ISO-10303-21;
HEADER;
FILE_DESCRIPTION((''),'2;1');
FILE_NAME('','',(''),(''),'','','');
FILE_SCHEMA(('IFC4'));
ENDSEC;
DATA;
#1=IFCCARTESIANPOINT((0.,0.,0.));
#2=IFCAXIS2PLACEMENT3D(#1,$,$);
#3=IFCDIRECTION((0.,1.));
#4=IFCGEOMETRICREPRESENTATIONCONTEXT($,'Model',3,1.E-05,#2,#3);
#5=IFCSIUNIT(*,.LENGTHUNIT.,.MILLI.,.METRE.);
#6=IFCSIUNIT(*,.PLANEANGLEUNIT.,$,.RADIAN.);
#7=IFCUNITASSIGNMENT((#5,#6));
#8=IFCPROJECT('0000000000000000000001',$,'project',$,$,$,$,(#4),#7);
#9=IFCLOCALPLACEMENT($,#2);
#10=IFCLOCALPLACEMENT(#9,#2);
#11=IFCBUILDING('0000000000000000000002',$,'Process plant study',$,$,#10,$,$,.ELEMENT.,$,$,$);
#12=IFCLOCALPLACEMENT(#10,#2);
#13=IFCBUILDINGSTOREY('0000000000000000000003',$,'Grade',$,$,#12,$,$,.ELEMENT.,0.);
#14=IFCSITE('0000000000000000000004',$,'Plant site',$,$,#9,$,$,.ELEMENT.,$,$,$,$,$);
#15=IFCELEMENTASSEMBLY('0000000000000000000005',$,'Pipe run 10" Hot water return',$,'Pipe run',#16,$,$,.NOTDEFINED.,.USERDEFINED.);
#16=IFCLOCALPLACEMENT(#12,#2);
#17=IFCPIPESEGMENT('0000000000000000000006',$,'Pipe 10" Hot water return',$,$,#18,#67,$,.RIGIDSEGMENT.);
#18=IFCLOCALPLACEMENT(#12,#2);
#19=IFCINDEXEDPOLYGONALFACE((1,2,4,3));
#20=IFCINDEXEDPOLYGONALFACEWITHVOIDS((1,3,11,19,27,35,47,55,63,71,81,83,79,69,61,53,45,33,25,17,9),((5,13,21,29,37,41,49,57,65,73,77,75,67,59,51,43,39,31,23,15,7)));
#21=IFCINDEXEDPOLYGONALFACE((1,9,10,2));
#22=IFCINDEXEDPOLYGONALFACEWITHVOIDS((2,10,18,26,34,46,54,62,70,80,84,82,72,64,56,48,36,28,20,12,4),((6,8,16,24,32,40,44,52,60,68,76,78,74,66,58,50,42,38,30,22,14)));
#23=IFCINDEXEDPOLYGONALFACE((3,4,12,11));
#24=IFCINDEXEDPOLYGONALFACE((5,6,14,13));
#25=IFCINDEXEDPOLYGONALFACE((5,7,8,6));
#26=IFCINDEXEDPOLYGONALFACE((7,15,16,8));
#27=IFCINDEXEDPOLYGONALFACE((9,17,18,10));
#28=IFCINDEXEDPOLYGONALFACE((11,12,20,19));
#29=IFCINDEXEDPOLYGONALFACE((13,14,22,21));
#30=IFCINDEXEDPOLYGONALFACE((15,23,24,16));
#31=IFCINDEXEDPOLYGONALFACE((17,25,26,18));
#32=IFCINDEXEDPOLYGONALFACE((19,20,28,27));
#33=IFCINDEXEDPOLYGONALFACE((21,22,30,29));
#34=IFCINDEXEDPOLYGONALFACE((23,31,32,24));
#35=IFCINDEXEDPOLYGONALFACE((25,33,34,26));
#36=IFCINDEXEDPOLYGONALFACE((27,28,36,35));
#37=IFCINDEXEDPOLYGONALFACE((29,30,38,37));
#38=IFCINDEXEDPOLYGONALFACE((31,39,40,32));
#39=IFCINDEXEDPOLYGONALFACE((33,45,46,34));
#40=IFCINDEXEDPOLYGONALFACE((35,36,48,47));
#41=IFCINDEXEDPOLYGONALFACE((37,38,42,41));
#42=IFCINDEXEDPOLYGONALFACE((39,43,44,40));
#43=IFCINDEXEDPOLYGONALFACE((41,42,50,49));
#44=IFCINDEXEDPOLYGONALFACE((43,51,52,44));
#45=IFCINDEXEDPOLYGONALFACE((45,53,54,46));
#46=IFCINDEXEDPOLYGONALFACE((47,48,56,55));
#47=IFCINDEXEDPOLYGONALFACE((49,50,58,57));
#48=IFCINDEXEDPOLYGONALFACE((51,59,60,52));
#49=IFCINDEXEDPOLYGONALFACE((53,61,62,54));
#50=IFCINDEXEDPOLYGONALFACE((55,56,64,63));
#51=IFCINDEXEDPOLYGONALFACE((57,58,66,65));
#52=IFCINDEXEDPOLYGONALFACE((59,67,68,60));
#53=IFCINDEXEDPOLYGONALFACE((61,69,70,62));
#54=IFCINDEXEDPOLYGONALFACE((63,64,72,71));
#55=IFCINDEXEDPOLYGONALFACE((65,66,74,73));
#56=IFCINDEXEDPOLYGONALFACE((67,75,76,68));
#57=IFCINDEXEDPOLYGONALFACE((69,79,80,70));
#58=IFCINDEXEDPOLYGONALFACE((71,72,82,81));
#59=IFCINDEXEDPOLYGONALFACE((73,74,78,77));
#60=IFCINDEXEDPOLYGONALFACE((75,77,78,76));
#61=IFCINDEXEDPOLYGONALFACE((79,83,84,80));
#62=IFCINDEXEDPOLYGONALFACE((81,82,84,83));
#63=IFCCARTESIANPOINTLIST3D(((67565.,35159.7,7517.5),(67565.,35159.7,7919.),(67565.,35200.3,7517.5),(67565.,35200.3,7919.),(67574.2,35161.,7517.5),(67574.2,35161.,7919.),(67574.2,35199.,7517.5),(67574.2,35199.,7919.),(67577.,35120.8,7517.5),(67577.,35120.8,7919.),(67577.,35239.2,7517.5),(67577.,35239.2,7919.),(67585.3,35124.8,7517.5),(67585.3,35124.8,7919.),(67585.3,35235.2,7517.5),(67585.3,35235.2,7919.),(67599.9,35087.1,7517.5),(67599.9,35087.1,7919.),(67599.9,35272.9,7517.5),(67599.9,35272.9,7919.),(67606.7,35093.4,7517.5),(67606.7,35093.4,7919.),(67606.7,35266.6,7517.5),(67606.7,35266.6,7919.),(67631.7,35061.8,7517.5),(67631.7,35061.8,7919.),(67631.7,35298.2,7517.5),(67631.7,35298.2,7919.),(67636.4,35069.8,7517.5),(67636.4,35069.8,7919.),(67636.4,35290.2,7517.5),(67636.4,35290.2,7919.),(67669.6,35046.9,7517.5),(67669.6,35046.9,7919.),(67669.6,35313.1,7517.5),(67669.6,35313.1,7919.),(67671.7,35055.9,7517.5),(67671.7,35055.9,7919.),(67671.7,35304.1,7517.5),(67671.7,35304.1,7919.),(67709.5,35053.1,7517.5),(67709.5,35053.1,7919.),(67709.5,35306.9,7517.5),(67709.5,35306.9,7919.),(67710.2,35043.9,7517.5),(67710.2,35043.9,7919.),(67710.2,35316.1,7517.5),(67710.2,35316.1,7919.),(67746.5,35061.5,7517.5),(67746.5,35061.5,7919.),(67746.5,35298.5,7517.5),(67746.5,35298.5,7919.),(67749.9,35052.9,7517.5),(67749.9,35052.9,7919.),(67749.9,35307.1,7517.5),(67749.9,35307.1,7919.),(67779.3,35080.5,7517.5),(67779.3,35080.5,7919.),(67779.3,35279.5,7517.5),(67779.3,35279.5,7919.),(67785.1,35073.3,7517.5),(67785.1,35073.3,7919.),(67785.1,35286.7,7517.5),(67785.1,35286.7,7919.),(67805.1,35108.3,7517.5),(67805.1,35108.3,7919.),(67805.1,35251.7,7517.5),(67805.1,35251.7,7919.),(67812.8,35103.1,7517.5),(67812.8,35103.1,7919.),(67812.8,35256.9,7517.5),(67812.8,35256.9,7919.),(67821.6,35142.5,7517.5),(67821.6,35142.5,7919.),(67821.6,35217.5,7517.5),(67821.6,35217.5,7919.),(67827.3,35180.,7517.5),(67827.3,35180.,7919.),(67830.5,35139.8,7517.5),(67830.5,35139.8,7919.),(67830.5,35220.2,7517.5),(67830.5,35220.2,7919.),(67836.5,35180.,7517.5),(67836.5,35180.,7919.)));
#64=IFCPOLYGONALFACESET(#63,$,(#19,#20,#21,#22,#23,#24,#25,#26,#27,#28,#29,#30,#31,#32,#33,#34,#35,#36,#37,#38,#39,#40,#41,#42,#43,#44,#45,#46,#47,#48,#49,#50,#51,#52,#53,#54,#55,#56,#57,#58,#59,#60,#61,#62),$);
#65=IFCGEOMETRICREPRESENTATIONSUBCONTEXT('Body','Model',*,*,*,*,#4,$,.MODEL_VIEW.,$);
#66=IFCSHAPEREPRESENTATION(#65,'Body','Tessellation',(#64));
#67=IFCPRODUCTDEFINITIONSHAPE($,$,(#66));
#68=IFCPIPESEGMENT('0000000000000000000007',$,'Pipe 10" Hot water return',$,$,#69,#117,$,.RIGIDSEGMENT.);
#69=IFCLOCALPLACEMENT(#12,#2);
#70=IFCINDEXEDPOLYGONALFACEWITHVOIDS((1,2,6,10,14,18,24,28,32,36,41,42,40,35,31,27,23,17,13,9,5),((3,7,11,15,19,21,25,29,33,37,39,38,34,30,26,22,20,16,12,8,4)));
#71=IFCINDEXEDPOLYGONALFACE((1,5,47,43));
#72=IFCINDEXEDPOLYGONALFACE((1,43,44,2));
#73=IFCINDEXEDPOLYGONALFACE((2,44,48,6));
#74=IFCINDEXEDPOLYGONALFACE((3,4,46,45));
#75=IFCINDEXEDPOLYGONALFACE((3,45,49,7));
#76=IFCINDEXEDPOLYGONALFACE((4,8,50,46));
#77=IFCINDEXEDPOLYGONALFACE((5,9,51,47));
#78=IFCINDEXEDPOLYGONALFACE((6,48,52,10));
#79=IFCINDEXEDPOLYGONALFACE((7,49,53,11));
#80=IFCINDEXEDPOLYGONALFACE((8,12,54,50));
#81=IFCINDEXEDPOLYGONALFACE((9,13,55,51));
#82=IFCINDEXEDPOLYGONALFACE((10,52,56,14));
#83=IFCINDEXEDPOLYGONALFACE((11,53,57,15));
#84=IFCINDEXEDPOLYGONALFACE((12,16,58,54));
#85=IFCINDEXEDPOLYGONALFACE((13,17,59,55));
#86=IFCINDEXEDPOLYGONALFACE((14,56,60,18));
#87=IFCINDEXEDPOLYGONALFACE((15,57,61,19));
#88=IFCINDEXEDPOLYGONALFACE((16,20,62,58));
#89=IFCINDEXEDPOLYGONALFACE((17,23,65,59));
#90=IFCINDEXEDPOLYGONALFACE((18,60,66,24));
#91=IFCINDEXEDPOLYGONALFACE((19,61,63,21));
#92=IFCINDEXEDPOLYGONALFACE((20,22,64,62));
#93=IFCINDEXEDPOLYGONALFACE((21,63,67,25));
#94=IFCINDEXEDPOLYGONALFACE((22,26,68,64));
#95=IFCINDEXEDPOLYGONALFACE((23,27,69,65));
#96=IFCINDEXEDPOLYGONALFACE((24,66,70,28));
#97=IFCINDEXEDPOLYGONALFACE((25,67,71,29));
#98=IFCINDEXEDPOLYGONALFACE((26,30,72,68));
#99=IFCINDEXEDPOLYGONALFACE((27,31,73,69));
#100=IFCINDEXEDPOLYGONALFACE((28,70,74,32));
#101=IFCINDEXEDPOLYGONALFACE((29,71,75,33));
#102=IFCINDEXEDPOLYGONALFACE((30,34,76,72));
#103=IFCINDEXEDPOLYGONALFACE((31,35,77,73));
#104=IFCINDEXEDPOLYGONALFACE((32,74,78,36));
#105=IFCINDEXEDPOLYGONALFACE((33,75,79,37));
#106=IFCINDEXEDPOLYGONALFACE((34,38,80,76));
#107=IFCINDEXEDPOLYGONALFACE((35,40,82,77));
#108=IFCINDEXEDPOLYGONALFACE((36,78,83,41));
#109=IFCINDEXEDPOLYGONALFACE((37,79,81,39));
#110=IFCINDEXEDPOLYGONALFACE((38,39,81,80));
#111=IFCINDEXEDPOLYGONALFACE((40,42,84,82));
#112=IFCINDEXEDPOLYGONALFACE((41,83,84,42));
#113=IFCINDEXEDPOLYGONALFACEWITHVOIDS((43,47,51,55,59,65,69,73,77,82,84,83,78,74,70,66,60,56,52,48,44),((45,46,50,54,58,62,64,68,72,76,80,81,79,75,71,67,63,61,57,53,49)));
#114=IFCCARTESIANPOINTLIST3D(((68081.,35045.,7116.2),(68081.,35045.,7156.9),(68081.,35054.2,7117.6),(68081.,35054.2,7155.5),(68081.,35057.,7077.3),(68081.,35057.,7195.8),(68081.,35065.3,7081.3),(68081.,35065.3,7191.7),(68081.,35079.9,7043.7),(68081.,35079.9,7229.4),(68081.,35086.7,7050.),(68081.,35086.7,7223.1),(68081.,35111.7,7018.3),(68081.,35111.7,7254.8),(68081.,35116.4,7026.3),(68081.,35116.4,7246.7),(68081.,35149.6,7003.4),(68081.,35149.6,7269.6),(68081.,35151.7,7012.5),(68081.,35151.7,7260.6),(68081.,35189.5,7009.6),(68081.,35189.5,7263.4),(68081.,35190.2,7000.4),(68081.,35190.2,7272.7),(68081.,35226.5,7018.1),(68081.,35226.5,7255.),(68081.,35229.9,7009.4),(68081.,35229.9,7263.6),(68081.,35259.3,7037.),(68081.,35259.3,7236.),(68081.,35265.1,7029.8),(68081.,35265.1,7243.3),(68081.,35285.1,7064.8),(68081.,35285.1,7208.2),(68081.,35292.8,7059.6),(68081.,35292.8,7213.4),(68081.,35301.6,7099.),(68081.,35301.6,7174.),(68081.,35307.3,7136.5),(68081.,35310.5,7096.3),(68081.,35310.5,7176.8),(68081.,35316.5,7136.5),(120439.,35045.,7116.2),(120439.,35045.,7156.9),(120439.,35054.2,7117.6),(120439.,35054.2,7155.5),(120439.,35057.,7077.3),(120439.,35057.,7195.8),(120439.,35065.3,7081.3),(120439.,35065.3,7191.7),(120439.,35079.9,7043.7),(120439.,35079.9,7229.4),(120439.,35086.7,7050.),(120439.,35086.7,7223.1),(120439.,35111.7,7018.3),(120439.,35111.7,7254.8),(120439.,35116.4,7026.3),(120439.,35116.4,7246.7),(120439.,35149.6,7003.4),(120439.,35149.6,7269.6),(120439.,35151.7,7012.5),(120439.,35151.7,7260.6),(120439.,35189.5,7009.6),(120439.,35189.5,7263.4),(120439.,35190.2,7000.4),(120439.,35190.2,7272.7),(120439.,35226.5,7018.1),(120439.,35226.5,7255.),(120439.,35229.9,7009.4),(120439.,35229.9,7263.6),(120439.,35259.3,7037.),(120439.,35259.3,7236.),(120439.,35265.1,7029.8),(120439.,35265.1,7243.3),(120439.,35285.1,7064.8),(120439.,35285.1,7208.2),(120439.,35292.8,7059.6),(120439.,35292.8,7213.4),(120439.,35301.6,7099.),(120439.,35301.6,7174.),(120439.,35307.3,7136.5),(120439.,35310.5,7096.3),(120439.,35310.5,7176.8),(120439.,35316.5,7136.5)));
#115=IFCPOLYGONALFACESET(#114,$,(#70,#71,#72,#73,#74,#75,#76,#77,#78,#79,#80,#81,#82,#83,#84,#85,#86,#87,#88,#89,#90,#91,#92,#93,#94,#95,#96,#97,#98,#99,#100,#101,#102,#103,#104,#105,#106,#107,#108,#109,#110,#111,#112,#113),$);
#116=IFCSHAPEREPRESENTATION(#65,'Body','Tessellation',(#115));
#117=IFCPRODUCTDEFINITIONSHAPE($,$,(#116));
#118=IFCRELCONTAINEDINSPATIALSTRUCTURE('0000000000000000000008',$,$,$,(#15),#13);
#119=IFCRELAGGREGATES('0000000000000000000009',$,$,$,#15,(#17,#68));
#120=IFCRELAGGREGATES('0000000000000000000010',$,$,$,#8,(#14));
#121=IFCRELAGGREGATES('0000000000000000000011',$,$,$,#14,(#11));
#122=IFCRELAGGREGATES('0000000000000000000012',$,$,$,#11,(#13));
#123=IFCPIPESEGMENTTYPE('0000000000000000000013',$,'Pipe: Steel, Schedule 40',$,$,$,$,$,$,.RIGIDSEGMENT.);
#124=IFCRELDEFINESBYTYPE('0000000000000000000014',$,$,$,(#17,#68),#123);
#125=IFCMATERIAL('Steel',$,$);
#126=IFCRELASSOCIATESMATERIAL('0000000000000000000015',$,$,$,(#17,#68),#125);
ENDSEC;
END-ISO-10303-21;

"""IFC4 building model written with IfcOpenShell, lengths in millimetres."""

from ifc_helpers import new_model, si_unit, direction, frame, origin, origin_with_axes, origin_2d, place, context, subcontext, project, spatial, hollow_circle, extrude, material, type_object, element, aggregate, save


model = new_model("IFC4")

# Units and contexts
model_context = context("Model", 3, precision=1e-05, world=origin(), true_north=direction((0.0, 1.0)))
body_context = subcontext(model_context, "Body", "Model", "MODEL_VIEW")
ifc_project = project(units=[si_unit("LENGTHUNIT", "METRE", prefix="MILLI"), si_unit("PLANEANGLEUNIT", "RADIAN")], contexts=[model_context])

# Site, building, storey
site_placement = place(None, origin())
site = spatial("IfcSite", under=ifc_project, at=site_placement, Name="Plant site", CompositionType="ELEMENT")
building_placement = place(site_placement, origin())
building = spatial("IfcBuilding", under=site, at=building_placement, Name="Process plant study", CompositionType="ELEMENT")
storey_placement = place(building_placement, origin())
storey = spatial("IfcBuildingStorey", under=building, at=storey_placement, Name="Grade", CompositionType="ELEMENT", Elevation=0.0)

# Shared definitions
ifc_material = material(Name="Steel")
pipe_segment_type = type_object("IfcPipeSegmentType", Name="Pipe: Steel, Schedule 40", PredefinedType="RIGIDSEGMENT")

# Element assembly, pipe segments
assembly_1_placement = place(storey_placement, origin_with_axes())
assembly_1 = element("IfcElementAssembly", 1, at=assembly_1_placement, inside=storey, Name="Pipe run 10\" Hot water return", ObjectType="Pipe run", AssemblyPlace="NOTDEFINED", PredefinedType="USERDEFINED")
pipe_segment_1_placement = place(storey_placement, origin_with_axes())
pipe_segment_1 = element("IfcPipeSegment", 2, at=pipe_segment_1_placement, type_object=pipe_segment_type, material=ifc_material, Name="Pipe 10\" Hot water return", PredefinedType="RIGIDSEGMENT", context=body_context, shape_type="SweptSolid", body=[
    extrude(hollow_circle(Radius=136.5, WallThickness=9.3, at=origin_2d()), frame((67700.0, 35180.0, 7919.0), z_axis=(0.0, 0.0, -1.0), x_axis=(1.0, 0.0, 0.0)), (0.0, 0.0, 1.0), 401.5),
])
pipe_segment_2_placement = place(storey_placement, origin_with_axes())
pipe_segment_2 = element("IfcPipeSegment", 3, at=pipe_segment_2_placement, type_object=pipe_segment_type, material=ifc_material, Name="Pipe 10\" Hot water return", PredefinedType="RIGIDSEGMENT", context=body_context, shape_type="SweptSolid", body=[
    extrude(hollow_circle(Radius=136.5, WallThickness=9.3, at=origin_2d()), frame((68081.0, 35180.0, 7136.5), z_axis=(1.0, 0.0, 0.0), x_axis=(0.0, 1.0, 0.0)), (0.0, 0.0, 1.0), 52358.0),
])

aggregate(assembly_1, [pipe_segment_1, pipe_segment_2])

save(model, "model.ifc")
